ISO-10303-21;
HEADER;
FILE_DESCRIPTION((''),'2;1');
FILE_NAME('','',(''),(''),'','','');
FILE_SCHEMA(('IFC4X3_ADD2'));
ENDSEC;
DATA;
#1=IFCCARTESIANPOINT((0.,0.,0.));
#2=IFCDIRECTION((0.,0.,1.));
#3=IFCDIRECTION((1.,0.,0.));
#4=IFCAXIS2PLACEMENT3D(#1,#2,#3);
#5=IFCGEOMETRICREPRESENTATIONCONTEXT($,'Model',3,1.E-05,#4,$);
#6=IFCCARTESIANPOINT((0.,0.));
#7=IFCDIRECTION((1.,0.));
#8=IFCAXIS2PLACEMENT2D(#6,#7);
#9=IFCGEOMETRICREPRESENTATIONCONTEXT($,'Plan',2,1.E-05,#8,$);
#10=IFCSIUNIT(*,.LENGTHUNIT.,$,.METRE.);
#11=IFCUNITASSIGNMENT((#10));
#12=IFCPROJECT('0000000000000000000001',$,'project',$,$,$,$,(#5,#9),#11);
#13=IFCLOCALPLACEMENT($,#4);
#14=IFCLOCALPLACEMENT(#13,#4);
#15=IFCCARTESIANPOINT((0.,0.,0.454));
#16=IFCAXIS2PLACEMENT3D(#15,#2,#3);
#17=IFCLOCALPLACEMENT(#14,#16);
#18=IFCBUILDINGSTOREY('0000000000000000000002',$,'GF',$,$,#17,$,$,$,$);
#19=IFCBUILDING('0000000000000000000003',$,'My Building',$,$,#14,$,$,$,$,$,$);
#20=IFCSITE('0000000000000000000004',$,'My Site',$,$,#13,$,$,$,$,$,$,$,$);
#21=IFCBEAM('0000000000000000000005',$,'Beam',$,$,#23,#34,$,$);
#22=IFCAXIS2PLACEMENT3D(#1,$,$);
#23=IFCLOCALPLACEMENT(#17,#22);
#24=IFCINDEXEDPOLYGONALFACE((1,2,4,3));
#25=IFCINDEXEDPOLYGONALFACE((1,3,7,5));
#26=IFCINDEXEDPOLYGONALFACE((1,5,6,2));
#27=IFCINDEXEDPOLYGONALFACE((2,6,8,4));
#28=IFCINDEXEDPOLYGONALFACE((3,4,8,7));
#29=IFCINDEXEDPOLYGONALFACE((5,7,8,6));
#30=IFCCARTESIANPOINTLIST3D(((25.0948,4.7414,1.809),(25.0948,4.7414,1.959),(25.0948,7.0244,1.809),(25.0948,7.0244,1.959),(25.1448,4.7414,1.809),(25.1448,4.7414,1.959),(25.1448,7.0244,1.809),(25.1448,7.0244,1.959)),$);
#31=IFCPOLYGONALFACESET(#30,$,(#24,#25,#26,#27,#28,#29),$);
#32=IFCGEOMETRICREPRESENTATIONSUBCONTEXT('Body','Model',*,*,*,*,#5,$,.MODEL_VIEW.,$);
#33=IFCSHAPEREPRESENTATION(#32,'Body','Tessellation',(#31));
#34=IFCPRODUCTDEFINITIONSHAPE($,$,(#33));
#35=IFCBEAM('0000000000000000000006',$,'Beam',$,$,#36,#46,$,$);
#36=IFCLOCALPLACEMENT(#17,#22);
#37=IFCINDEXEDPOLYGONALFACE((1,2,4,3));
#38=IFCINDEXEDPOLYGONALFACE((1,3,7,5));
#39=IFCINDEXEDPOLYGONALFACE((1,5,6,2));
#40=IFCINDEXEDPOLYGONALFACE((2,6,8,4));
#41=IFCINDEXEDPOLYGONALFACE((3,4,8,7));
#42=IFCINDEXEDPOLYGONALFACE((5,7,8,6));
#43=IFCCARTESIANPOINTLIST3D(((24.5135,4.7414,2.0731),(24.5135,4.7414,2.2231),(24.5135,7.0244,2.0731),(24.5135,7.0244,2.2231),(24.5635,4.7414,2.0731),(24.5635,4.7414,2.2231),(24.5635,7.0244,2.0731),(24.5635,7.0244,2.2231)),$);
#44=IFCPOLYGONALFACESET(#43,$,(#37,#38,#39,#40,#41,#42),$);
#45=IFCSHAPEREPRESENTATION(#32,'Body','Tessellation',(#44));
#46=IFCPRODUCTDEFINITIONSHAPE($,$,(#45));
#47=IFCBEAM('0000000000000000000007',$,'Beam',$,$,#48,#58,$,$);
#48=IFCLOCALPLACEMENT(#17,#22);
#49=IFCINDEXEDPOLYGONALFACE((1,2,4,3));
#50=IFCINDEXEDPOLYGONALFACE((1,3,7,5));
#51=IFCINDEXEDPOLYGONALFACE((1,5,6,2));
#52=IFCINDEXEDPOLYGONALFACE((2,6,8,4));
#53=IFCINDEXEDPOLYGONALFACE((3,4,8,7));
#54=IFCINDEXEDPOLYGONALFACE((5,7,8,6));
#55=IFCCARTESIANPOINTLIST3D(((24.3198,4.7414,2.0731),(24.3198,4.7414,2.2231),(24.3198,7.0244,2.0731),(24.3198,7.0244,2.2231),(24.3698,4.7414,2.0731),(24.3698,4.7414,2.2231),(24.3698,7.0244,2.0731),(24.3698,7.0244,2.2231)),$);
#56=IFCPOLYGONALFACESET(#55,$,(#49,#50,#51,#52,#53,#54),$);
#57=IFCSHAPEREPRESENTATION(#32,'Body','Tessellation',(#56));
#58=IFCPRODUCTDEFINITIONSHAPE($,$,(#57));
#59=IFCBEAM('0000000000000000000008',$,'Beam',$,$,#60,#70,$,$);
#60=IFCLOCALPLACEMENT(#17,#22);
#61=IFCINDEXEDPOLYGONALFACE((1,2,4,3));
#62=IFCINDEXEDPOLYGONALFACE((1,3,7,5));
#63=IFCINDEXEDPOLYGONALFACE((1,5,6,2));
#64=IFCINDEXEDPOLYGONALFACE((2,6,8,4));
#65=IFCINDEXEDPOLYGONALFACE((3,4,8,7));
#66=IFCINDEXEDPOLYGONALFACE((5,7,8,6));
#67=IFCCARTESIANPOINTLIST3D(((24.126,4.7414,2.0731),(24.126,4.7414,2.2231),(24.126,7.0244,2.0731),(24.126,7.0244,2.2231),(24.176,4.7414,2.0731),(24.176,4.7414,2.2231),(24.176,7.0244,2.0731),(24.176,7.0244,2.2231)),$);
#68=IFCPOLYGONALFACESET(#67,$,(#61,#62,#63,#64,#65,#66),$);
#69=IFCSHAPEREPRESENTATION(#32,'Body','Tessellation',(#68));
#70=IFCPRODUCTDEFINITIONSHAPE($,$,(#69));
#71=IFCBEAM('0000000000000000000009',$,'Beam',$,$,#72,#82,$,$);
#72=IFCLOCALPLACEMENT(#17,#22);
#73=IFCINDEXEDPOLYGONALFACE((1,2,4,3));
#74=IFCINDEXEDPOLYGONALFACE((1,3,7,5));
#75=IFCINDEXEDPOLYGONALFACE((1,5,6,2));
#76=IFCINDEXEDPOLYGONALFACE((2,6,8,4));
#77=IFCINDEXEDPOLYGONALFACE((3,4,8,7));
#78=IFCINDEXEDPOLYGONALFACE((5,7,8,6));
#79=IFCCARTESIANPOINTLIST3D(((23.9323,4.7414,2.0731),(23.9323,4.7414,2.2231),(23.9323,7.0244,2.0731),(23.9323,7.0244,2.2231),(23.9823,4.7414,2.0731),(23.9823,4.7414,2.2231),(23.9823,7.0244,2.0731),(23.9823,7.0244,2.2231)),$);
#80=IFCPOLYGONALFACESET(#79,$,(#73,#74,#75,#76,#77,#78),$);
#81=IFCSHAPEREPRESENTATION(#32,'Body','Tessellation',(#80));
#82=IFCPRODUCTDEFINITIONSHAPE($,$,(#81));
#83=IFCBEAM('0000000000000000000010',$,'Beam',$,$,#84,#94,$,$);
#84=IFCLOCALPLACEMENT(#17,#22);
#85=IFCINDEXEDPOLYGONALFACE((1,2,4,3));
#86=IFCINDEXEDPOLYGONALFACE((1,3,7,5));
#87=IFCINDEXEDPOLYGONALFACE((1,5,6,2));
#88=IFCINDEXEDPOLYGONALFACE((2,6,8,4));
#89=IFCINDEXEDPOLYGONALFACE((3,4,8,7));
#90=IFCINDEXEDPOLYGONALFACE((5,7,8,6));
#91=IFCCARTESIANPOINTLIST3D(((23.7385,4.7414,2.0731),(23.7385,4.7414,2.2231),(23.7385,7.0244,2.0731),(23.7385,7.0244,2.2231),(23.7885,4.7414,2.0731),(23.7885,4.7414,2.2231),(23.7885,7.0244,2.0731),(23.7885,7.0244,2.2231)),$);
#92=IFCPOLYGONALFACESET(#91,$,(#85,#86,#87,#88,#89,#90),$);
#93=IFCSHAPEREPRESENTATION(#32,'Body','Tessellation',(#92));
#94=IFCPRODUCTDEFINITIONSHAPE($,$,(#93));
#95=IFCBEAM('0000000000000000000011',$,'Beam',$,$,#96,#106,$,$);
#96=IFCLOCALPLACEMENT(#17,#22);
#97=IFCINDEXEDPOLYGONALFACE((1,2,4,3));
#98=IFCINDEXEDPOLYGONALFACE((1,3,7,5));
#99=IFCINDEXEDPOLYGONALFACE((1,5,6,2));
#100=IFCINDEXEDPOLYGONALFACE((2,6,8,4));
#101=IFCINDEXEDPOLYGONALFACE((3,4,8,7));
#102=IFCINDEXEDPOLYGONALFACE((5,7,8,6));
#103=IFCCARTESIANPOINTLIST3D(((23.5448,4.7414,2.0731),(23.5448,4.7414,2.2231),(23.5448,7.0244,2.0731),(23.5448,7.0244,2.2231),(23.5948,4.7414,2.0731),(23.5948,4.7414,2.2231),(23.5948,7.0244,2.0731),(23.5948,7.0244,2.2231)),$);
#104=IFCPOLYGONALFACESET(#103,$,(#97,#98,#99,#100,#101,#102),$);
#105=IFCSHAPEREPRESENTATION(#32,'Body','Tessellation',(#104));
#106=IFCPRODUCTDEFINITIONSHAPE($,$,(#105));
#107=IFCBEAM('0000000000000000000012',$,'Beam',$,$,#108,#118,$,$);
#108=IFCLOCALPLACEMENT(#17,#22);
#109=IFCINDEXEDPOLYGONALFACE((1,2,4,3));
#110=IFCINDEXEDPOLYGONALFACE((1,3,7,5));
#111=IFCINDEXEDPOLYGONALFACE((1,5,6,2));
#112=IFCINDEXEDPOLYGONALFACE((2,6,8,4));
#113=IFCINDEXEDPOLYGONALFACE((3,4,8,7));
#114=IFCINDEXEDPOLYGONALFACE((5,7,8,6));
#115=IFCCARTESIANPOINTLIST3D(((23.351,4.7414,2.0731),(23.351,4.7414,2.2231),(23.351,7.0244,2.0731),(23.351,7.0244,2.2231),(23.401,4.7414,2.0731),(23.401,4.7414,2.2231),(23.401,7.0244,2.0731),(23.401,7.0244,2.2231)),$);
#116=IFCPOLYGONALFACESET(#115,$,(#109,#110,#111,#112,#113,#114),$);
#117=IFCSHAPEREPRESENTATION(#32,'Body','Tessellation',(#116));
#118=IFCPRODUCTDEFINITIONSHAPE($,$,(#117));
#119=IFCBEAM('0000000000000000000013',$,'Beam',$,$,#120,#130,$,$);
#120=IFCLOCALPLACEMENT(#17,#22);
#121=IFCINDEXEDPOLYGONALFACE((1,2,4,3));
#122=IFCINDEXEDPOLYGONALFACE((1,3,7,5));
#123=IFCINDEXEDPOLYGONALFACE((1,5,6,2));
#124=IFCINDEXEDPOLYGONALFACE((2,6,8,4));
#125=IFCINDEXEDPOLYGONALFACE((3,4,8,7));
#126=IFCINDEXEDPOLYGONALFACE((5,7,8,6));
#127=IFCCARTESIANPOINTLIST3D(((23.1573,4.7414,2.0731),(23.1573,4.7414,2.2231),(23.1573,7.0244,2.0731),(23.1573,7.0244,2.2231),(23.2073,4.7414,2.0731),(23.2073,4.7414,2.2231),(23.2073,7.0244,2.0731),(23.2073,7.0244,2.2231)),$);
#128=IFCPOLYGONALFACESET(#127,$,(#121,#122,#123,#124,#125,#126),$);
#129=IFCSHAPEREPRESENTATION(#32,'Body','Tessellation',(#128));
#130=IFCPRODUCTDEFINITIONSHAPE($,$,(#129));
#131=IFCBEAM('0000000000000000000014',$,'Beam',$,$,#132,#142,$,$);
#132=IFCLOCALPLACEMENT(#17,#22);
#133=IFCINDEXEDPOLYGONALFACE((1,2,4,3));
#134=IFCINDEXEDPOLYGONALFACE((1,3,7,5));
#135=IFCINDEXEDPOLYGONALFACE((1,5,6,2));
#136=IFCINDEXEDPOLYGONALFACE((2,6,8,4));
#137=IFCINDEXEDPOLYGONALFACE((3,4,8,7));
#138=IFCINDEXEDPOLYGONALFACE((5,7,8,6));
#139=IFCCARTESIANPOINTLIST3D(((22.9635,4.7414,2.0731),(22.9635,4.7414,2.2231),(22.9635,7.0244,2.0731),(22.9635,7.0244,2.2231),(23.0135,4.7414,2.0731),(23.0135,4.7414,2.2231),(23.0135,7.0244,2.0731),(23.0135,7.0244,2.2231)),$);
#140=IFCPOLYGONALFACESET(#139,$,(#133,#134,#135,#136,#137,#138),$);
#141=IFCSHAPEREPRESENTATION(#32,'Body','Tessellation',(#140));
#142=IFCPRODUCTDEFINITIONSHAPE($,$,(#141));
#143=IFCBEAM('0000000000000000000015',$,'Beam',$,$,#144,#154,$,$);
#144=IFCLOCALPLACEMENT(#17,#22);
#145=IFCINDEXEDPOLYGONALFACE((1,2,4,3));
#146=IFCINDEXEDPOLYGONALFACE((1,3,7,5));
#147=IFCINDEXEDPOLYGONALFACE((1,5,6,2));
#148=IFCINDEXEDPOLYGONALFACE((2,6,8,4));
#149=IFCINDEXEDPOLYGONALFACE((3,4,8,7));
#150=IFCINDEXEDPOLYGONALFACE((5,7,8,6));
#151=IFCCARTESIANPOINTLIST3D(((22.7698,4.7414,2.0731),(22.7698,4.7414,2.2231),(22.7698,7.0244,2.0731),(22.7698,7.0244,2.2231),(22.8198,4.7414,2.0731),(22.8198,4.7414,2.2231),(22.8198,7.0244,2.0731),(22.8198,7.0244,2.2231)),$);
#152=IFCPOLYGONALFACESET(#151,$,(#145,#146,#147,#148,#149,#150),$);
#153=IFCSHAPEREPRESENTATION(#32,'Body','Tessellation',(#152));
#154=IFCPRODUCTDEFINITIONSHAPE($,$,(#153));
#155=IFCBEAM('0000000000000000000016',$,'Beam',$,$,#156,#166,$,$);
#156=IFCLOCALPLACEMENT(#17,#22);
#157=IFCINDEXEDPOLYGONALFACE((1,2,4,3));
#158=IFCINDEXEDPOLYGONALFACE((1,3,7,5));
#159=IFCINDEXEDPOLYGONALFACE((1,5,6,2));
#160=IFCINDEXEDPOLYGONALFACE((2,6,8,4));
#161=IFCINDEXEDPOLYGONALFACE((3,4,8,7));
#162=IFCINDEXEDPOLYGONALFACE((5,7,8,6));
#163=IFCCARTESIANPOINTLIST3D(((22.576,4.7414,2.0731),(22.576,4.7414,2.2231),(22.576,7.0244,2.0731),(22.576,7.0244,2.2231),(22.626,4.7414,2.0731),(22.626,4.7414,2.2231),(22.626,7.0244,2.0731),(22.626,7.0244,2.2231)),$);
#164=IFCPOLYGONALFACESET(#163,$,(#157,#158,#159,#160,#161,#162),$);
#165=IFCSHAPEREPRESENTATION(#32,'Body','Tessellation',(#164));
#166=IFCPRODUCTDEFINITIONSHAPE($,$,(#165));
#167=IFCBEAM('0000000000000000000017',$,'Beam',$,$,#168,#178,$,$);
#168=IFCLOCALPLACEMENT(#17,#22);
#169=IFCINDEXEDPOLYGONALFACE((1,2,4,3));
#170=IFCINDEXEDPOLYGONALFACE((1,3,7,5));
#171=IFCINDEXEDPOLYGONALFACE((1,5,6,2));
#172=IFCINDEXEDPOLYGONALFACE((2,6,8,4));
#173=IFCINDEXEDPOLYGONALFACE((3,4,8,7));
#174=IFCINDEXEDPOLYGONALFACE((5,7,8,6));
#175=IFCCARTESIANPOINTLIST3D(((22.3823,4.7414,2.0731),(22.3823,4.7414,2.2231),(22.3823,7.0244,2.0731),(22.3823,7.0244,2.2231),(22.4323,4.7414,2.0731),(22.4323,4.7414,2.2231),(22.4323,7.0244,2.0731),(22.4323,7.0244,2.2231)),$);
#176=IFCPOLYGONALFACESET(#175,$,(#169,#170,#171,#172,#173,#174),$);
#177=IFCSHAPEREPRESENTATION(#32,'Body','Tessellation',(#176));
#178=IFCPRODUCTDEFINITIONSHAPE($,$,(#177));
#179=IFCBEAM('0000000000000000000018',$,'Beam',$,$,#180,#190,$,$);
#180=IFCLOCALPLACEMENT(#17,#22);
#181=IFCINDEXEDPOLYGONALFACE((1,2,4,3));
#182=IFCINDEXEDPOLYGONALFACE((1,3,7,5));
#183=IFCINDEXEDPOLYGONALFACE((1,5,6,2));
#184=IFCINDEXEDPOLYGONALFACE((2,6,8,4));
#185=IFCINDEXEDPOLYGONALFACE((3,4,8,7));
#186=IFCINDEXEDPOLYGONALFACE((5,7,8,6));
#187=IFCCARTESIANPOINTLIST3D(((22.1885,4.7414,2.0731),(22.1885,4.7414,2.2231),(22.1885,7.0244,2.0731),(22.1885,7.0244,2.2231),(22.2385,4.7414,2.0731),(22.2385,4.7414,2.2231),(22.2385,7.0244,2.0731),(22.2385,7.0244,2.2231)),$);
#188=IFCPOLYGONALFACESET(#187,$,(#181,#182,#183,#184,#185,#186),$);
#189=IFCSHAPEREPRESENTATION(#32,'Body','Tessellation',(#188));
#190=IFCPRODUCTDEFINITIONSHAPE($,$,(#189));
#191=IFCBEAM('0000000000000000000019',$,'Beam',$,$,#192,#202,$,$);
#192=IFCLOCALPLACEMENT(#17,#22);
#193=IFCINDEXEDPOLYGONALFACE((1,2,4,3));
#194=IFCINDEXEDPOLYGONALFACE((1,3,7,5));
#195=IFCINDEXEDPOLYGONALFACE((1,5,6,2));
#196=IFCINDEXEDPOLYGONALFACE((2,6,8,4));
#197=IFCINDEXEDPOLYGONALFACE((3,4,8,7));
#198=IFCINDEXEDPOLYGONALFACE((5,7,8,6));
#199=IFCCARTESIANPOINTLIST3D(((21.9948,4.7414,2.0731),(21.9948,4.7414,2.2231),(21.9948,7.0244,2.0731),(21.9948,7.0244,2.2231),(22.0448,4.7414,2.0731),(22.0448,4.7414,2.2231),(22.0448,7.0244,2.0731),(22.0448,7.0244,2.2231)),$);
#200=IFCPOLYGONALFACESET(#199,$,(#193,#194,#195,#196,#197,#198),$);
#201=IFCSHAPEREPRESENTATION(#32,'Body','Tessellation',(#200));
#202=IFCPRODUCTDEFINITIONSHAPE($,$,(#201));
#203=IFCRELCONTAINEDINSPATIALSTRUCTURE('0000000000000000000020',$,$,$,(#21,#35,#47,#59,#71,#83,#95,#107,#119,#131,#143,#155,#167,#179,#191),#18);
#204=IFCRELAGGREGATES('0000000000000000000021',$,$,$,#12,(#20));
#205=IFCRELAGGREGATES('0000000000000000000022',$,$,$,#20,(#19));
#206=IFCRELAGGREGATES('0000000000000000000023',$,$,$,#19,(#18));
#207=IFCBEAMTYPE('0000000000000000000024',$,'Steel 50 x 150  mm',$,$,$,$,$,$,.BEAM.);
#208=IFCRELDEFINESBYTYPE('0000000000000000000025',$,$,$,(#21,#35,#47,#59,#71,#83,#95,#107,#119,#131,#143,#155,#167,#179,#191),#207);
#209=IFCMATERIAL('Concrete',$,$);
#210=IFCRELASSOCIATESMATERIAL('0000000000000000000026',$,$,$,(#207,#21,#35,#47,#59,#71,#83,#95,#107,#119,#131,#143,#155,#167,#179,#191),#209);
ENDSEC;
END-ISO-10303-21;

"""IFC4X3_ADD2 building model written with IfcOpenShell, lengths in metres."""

from ifc_helpers import new_model, si_unit, frame, origin_with_axes, origin_2d_with_axis, place, context, subcontext, project, spatial, rectangle, extrude, material, material_profile, profile_set, profile_usage, type_object, element, save


model = new_model("IFC4X3_ADD2")

# Units and contexts
model_context = context("Model", 3, precision=1e-05, world=origin_with_axes())
plan_context = context("Plan", 2, precision=1e-05, world=origin_2d_with_axis())
body_context_1 = subcontext(model_context, "Body", "Model", "MODEL_VIEW")
ifc_project = project(units=[si_unit("LENGTHUNIT", "METRE")], contexts=[model_context, plan_context])

# Site, building, storey
site_placement = place(None, origin_with_axes())
site = spatial("IfcSite", under=ifc_project, at=site_placement, Name="My Site")
building_placement = place(site_placement, origin_with_axes())
building = spatial("IfcBuilding", under=site, at=building_placement, Name="My Building")
storey_placement = place(building_placement, frame((0.0, 0.0, 0.454), z_axis=(0.0, 0.0, 1.0), x_axis=(1.0, 0.0, 0.0)))
storey = spatial("IfcBuildingStorey", under=building, at=storey_placement, Name="GF")

# Beams
ifc_material = material(Name="Concrete")
ifc_material_profile = material_profile(ifc_material, rectangle(XDim=0.05, YDim=0.15))
ifc_profile_set = profile_set([ifc_material_profile])
ifc_profile_usage_1 = profile_usage(ifc_profile_set)
beam_type = type_object("IfcBeamType", Name="Steel 50 x 150  mm", PredefinedType="BEAM", material=ifc_profile_set)
beam_1_placement = place(storey_placement, frame((25.1198, 7.0244, 1.884), z_axis=(0.0, -1.0, 0.0), x_axis=(1.0, 0.0, 0.0)))
element("IfcBeam", 1, at=beam_1_placement, inside=storey, type_object=beam_type, material=ifc_profile_usage_1, Name="Beam", context=body_context_1, shape_type="SweptSolid", body=[
    extrude(rectangle(XDim=0.05, YDim=0.15), origin_with_axes(), (0.0, 0.0, 1.0), 2.283),
])
ifc_profile_usage_2 = profile_usage(ifc_profile_set)
beam_2_placement = place(storey_placement, frame((24.5385, 7.0244, 2.1481), z_axis=(0.0, -1.0, 0.0), x_axis=(1.0, 0.0, 0.0)))
element("IfcBeam", 2, at=beam_2_placement, inside=storey, type_object=beam_type, material=ifc_profile_usage_2, Name="Beam", context=body_context_1, shape_type="SweptSolid", body=[
    extrude(rectangle(XDim=0.05, YDim=0.15), origin_with_axes(), (0.0, 0.0, 1.0), 2.283),
])
ifc_profile_usage_3 = profile_usage(ifc_profile_set)
beam_3_placement = place(storey_placement, frame((24.3448, 7.0244, 2.1481), z_axis=(0.0, -1.0, 0.0), x_axis=(1.0, 0.0, 0.0)))
element("IfcBeam", 3, at=beam_3_placement, inside=storey, type_object=beam_type, material=ifc_profile_usage_3, Name="Beam", context=body_context_1, shape_type="SweptSolid", body=[
    extrude(rectangle(XDim=0.05, YDim=0.15), origin_with_axes(), (0.0, 0.0, 1.0), 2.283),
])
ifc_profile_usage_4 = profile_usage(ifc_profile_set)
beam_4_placement = place(storey_placement, frame((24.151, 7.0244, 2.1481), z_axis=(0.0, -1.0, 0.0), x_axis=(1.0, 0.0, 0.0)))
element("IfcBeam", 4, at=beam_4_placement, inside=storey, type_object=beam_type, material=ifc_profile_usage_4, Name="Beam", context=body_context_1, shape_type="SweptSolid", body=[
    extrude(rectangle(XDim=0.05, YDim=0.15), origin_with_axes(), (0.0, 0.0, 1.0), 2.283),
])
ifc_profile_usage_5 = profile_usage(ifc_profile_set)
beam_5_placement = place(storey_placement, frame((23.9573, 7.0244, 2.1481), z_axis=(0.0, -1.0, 0.0), x_axis=(1.0, 0.0, 0.0)))
element("IfcBeam", 5, at=beam_5_placement, inside=storey, type_object=beam_type, material=ifc_profile_usage_5, Name="Beam", context=body_context_1, shape_type="SweptSolid", body=[
    extrude(rectangle(XDim=0.05, YDim=0.15), origin_with_axes(), (0.0, 0.0, 1.0), 2.283),
])
ifc_profile_usage_6 = profile_usage(ifc_profile_set)
beam_6_placement = place(storey_placement, frame((23.7635, 7.0244, 2.1481), z_axis=(0.0, -1.0, 0.0), x_axis=(1.0, 0.0, 0.0)))
element("IfcBeam", 6, at=beam_6_placement, inside=storey, type_object=beam_type, material=ifc_profile_usage_6, Name="Beam", context=body_context_1, shape_type="SweptSolid", body=[
    extrude(rectangle(XDim=0.05, YDim=0.15), origin_with_axes(), (0.0, 0.0, 1.0), 2.283),
])
ifc_profile_usage_7 = profile_usage(ifc_profile_set)
beam_7_placement = place(storey_placement, frame((23.5698, 7.0244, 2.1481), z_axis=(0.0, -1.0, 0.0), x_axis=(1.0, 0.0, 0.0)))
element("IfcBeam", 7, at=beam_7_placement, inside=storey, type_object=beam_type, material=ifc_profile_usage_7, Name="Beam", context=body_context_1, shape_type="SweptSolid", body=[
    extrude(rectangle(XDim=0.05, YDim=0.15), origin_with_axes(), (0.0, 0.0, 1.0), 2.283),
])
ifc_profile_usage_8 = profile_usage(ifc_profile_set)
beam_8_placement = place(storey_placement, frame((23.376, 7.0244, 2.1481), z_axis=(0.0, -1.0, 0.0), x_axis=(1.0, 0.0, 0.0)))
element("IfcBeam", 8, at=beam_8_placement, inside=storey, type_object=beam_type, material=ifc_profile_usage_8, Name="Beam", context=body_context_1, shape_type="SweptSolid", body=[
    extrude(rectangle(XDim=0.05, YDim=0.15), origin_with_axes(), (0.0, 0.0, 1.0), 2.283),
])
ifc_profile_usage_9 = profile_usage(ifc_profile_set)
beam_9_placement = place(storey_placement, frame((23.1823, 7.0244, 2.1481), z_axis=(0.0, -1.0, 0.0), x_axis=(1.0, 0.0, 0.0)))
element("IfcBeam", 9, at=beam_9_placement, inside=storey, type_object=beam_type, material=ifc_profile_usage_9, Name="Beam", context=body_context_1, shape_type="SweptSolid", body=[
    extrude(rectangle(XDim=0.05, YDim=0.15), origin_with_axes(), (0.0, 0.0, 1.0), 2.283),
])
ifc_profile_usage_10 = profile_usage(ifc_profile_set)
beam_10_placement = place(storey_placement, frame((22.9885, 7.0244, 2.1481), z_axis=(0.0, -1.0, 0.0), x_axis=(1.0, 0.0, 0.0)))
element("IfcBeam", 10, at=beam_10_placement, inside=storey, type_object=beam_type, material=ifc_profile_usage_10, Name="Beam", context=body_context_1, shape_type="SweptSolid", body=[
    extrude(rectangle(XDim=0.05, YDim=0.15), origin_with_axes(), (0.0, 0.0, 1.0), 2.283),
])
ifc_profile_usage_11 = profile_usage(ifc_profile_set)
beam_11_placement = place(storey_placement, frame((22.7948, 7.0244, 2.1481), z_axis=(0.0, -1.0, 0.0), x_axis=(1.0, 0.0, 0.0)))
element("IfcBeam", 11, at=beam_11_placement, inside=storey, type_object=beam_type, material=ifc_profile_usage_11, Name="Beam", context=body_context_1, shape_type="SweptSolid", body=[
    extrude(rectangle(XDim=0.05, YDim=0.15), origin_with_axes(), (0.0, 0.0, 1.0), 2.283),
])
ifc_profile_usage_12 = profile_usage(ifc_profile_set)
beam_12_placement = place(storey_placement, frame((22.601, 7.0244, 2.1481), z_axis=(0.0, -1.0, 0.0), x_axis=(1.0, 0.0, 0.0)))
element("IfcBeam", 12, at=beam_12_placement, inside=storey, type_object=beam_type, material=ifc_profile_usage_12, Name="Beam", context=body_context_1, shape_type="SweptSolid", body=[
    extrude(rectangle(XDim=0.05, YDim=0.15), origin_with_axes(), (0.0, 0.0, 1.0), 2.283),
])
ifc_profile_usage_13 = profile_usage(ifc_profile_set)
beam_13_placement = place(storey_placement, frame((22.4073, 7.0244, 2.1481), z_axis=(0.0, -1.0, 0.0), x_axis=(1.0, 0.0, 0.0)))
element("IfcBeam", 13, at=beam_13_placement, inside=storey, type_object=beam_type, material=ifc_profile_usage_13, Name="Beam", context=body_context_1, shape_type="SweptSolid", body=[
    extrude(rectangle(XDim=0.05, YDim=0.15), origin_with_axes(), (0.0, 0.0, 1.0), 2.283),
])
ifc_profile_usage_14 = profile_usage(ifc_profile_set)
beam_14_placement = place(storey_placement, frame((22.2135, 7.0244, 2.1481), z_axis=(0.0, -1.0, 0.0), x_axis=(1.0, 0.0, 0.0)))
element("IfcBeam", 14, at=beam_14_placement, inside=storey, type_object=beam_type, material=ifc_profile_usage_14, Name="Beam", context=body_context_1, shape_type="SweptSolid", body=[
    extrude(rectangle(XDim=0.05, YDim=0.15), origin_with_axes(), (0.0, 0.0, 1.0), 2.283),
])
ifc_profile_usage_15 = profile_usage(ifc_profile_set)
beam_15_placement = place(storey_placement, frame((22.0198, 7.0244, 2.1481), z_axis=(0.0, -1.0, 0.0), x_axis=(1.0, 0.0, 0.0)))
element("IfcBeam", 15, at=beam_15_placement, inside=storey, type_object=beam_type, material=ifc_profile_usage_15, Name="Beam", context=body_context_1, shape_type="SweptSolid", body=[
    extrude(rectangle(XDim=0.05, YDim=0.15), origin_with_axes(), (0.0, 0.0, 1.0), 2.283),
])

save(model, "model.ifc")
